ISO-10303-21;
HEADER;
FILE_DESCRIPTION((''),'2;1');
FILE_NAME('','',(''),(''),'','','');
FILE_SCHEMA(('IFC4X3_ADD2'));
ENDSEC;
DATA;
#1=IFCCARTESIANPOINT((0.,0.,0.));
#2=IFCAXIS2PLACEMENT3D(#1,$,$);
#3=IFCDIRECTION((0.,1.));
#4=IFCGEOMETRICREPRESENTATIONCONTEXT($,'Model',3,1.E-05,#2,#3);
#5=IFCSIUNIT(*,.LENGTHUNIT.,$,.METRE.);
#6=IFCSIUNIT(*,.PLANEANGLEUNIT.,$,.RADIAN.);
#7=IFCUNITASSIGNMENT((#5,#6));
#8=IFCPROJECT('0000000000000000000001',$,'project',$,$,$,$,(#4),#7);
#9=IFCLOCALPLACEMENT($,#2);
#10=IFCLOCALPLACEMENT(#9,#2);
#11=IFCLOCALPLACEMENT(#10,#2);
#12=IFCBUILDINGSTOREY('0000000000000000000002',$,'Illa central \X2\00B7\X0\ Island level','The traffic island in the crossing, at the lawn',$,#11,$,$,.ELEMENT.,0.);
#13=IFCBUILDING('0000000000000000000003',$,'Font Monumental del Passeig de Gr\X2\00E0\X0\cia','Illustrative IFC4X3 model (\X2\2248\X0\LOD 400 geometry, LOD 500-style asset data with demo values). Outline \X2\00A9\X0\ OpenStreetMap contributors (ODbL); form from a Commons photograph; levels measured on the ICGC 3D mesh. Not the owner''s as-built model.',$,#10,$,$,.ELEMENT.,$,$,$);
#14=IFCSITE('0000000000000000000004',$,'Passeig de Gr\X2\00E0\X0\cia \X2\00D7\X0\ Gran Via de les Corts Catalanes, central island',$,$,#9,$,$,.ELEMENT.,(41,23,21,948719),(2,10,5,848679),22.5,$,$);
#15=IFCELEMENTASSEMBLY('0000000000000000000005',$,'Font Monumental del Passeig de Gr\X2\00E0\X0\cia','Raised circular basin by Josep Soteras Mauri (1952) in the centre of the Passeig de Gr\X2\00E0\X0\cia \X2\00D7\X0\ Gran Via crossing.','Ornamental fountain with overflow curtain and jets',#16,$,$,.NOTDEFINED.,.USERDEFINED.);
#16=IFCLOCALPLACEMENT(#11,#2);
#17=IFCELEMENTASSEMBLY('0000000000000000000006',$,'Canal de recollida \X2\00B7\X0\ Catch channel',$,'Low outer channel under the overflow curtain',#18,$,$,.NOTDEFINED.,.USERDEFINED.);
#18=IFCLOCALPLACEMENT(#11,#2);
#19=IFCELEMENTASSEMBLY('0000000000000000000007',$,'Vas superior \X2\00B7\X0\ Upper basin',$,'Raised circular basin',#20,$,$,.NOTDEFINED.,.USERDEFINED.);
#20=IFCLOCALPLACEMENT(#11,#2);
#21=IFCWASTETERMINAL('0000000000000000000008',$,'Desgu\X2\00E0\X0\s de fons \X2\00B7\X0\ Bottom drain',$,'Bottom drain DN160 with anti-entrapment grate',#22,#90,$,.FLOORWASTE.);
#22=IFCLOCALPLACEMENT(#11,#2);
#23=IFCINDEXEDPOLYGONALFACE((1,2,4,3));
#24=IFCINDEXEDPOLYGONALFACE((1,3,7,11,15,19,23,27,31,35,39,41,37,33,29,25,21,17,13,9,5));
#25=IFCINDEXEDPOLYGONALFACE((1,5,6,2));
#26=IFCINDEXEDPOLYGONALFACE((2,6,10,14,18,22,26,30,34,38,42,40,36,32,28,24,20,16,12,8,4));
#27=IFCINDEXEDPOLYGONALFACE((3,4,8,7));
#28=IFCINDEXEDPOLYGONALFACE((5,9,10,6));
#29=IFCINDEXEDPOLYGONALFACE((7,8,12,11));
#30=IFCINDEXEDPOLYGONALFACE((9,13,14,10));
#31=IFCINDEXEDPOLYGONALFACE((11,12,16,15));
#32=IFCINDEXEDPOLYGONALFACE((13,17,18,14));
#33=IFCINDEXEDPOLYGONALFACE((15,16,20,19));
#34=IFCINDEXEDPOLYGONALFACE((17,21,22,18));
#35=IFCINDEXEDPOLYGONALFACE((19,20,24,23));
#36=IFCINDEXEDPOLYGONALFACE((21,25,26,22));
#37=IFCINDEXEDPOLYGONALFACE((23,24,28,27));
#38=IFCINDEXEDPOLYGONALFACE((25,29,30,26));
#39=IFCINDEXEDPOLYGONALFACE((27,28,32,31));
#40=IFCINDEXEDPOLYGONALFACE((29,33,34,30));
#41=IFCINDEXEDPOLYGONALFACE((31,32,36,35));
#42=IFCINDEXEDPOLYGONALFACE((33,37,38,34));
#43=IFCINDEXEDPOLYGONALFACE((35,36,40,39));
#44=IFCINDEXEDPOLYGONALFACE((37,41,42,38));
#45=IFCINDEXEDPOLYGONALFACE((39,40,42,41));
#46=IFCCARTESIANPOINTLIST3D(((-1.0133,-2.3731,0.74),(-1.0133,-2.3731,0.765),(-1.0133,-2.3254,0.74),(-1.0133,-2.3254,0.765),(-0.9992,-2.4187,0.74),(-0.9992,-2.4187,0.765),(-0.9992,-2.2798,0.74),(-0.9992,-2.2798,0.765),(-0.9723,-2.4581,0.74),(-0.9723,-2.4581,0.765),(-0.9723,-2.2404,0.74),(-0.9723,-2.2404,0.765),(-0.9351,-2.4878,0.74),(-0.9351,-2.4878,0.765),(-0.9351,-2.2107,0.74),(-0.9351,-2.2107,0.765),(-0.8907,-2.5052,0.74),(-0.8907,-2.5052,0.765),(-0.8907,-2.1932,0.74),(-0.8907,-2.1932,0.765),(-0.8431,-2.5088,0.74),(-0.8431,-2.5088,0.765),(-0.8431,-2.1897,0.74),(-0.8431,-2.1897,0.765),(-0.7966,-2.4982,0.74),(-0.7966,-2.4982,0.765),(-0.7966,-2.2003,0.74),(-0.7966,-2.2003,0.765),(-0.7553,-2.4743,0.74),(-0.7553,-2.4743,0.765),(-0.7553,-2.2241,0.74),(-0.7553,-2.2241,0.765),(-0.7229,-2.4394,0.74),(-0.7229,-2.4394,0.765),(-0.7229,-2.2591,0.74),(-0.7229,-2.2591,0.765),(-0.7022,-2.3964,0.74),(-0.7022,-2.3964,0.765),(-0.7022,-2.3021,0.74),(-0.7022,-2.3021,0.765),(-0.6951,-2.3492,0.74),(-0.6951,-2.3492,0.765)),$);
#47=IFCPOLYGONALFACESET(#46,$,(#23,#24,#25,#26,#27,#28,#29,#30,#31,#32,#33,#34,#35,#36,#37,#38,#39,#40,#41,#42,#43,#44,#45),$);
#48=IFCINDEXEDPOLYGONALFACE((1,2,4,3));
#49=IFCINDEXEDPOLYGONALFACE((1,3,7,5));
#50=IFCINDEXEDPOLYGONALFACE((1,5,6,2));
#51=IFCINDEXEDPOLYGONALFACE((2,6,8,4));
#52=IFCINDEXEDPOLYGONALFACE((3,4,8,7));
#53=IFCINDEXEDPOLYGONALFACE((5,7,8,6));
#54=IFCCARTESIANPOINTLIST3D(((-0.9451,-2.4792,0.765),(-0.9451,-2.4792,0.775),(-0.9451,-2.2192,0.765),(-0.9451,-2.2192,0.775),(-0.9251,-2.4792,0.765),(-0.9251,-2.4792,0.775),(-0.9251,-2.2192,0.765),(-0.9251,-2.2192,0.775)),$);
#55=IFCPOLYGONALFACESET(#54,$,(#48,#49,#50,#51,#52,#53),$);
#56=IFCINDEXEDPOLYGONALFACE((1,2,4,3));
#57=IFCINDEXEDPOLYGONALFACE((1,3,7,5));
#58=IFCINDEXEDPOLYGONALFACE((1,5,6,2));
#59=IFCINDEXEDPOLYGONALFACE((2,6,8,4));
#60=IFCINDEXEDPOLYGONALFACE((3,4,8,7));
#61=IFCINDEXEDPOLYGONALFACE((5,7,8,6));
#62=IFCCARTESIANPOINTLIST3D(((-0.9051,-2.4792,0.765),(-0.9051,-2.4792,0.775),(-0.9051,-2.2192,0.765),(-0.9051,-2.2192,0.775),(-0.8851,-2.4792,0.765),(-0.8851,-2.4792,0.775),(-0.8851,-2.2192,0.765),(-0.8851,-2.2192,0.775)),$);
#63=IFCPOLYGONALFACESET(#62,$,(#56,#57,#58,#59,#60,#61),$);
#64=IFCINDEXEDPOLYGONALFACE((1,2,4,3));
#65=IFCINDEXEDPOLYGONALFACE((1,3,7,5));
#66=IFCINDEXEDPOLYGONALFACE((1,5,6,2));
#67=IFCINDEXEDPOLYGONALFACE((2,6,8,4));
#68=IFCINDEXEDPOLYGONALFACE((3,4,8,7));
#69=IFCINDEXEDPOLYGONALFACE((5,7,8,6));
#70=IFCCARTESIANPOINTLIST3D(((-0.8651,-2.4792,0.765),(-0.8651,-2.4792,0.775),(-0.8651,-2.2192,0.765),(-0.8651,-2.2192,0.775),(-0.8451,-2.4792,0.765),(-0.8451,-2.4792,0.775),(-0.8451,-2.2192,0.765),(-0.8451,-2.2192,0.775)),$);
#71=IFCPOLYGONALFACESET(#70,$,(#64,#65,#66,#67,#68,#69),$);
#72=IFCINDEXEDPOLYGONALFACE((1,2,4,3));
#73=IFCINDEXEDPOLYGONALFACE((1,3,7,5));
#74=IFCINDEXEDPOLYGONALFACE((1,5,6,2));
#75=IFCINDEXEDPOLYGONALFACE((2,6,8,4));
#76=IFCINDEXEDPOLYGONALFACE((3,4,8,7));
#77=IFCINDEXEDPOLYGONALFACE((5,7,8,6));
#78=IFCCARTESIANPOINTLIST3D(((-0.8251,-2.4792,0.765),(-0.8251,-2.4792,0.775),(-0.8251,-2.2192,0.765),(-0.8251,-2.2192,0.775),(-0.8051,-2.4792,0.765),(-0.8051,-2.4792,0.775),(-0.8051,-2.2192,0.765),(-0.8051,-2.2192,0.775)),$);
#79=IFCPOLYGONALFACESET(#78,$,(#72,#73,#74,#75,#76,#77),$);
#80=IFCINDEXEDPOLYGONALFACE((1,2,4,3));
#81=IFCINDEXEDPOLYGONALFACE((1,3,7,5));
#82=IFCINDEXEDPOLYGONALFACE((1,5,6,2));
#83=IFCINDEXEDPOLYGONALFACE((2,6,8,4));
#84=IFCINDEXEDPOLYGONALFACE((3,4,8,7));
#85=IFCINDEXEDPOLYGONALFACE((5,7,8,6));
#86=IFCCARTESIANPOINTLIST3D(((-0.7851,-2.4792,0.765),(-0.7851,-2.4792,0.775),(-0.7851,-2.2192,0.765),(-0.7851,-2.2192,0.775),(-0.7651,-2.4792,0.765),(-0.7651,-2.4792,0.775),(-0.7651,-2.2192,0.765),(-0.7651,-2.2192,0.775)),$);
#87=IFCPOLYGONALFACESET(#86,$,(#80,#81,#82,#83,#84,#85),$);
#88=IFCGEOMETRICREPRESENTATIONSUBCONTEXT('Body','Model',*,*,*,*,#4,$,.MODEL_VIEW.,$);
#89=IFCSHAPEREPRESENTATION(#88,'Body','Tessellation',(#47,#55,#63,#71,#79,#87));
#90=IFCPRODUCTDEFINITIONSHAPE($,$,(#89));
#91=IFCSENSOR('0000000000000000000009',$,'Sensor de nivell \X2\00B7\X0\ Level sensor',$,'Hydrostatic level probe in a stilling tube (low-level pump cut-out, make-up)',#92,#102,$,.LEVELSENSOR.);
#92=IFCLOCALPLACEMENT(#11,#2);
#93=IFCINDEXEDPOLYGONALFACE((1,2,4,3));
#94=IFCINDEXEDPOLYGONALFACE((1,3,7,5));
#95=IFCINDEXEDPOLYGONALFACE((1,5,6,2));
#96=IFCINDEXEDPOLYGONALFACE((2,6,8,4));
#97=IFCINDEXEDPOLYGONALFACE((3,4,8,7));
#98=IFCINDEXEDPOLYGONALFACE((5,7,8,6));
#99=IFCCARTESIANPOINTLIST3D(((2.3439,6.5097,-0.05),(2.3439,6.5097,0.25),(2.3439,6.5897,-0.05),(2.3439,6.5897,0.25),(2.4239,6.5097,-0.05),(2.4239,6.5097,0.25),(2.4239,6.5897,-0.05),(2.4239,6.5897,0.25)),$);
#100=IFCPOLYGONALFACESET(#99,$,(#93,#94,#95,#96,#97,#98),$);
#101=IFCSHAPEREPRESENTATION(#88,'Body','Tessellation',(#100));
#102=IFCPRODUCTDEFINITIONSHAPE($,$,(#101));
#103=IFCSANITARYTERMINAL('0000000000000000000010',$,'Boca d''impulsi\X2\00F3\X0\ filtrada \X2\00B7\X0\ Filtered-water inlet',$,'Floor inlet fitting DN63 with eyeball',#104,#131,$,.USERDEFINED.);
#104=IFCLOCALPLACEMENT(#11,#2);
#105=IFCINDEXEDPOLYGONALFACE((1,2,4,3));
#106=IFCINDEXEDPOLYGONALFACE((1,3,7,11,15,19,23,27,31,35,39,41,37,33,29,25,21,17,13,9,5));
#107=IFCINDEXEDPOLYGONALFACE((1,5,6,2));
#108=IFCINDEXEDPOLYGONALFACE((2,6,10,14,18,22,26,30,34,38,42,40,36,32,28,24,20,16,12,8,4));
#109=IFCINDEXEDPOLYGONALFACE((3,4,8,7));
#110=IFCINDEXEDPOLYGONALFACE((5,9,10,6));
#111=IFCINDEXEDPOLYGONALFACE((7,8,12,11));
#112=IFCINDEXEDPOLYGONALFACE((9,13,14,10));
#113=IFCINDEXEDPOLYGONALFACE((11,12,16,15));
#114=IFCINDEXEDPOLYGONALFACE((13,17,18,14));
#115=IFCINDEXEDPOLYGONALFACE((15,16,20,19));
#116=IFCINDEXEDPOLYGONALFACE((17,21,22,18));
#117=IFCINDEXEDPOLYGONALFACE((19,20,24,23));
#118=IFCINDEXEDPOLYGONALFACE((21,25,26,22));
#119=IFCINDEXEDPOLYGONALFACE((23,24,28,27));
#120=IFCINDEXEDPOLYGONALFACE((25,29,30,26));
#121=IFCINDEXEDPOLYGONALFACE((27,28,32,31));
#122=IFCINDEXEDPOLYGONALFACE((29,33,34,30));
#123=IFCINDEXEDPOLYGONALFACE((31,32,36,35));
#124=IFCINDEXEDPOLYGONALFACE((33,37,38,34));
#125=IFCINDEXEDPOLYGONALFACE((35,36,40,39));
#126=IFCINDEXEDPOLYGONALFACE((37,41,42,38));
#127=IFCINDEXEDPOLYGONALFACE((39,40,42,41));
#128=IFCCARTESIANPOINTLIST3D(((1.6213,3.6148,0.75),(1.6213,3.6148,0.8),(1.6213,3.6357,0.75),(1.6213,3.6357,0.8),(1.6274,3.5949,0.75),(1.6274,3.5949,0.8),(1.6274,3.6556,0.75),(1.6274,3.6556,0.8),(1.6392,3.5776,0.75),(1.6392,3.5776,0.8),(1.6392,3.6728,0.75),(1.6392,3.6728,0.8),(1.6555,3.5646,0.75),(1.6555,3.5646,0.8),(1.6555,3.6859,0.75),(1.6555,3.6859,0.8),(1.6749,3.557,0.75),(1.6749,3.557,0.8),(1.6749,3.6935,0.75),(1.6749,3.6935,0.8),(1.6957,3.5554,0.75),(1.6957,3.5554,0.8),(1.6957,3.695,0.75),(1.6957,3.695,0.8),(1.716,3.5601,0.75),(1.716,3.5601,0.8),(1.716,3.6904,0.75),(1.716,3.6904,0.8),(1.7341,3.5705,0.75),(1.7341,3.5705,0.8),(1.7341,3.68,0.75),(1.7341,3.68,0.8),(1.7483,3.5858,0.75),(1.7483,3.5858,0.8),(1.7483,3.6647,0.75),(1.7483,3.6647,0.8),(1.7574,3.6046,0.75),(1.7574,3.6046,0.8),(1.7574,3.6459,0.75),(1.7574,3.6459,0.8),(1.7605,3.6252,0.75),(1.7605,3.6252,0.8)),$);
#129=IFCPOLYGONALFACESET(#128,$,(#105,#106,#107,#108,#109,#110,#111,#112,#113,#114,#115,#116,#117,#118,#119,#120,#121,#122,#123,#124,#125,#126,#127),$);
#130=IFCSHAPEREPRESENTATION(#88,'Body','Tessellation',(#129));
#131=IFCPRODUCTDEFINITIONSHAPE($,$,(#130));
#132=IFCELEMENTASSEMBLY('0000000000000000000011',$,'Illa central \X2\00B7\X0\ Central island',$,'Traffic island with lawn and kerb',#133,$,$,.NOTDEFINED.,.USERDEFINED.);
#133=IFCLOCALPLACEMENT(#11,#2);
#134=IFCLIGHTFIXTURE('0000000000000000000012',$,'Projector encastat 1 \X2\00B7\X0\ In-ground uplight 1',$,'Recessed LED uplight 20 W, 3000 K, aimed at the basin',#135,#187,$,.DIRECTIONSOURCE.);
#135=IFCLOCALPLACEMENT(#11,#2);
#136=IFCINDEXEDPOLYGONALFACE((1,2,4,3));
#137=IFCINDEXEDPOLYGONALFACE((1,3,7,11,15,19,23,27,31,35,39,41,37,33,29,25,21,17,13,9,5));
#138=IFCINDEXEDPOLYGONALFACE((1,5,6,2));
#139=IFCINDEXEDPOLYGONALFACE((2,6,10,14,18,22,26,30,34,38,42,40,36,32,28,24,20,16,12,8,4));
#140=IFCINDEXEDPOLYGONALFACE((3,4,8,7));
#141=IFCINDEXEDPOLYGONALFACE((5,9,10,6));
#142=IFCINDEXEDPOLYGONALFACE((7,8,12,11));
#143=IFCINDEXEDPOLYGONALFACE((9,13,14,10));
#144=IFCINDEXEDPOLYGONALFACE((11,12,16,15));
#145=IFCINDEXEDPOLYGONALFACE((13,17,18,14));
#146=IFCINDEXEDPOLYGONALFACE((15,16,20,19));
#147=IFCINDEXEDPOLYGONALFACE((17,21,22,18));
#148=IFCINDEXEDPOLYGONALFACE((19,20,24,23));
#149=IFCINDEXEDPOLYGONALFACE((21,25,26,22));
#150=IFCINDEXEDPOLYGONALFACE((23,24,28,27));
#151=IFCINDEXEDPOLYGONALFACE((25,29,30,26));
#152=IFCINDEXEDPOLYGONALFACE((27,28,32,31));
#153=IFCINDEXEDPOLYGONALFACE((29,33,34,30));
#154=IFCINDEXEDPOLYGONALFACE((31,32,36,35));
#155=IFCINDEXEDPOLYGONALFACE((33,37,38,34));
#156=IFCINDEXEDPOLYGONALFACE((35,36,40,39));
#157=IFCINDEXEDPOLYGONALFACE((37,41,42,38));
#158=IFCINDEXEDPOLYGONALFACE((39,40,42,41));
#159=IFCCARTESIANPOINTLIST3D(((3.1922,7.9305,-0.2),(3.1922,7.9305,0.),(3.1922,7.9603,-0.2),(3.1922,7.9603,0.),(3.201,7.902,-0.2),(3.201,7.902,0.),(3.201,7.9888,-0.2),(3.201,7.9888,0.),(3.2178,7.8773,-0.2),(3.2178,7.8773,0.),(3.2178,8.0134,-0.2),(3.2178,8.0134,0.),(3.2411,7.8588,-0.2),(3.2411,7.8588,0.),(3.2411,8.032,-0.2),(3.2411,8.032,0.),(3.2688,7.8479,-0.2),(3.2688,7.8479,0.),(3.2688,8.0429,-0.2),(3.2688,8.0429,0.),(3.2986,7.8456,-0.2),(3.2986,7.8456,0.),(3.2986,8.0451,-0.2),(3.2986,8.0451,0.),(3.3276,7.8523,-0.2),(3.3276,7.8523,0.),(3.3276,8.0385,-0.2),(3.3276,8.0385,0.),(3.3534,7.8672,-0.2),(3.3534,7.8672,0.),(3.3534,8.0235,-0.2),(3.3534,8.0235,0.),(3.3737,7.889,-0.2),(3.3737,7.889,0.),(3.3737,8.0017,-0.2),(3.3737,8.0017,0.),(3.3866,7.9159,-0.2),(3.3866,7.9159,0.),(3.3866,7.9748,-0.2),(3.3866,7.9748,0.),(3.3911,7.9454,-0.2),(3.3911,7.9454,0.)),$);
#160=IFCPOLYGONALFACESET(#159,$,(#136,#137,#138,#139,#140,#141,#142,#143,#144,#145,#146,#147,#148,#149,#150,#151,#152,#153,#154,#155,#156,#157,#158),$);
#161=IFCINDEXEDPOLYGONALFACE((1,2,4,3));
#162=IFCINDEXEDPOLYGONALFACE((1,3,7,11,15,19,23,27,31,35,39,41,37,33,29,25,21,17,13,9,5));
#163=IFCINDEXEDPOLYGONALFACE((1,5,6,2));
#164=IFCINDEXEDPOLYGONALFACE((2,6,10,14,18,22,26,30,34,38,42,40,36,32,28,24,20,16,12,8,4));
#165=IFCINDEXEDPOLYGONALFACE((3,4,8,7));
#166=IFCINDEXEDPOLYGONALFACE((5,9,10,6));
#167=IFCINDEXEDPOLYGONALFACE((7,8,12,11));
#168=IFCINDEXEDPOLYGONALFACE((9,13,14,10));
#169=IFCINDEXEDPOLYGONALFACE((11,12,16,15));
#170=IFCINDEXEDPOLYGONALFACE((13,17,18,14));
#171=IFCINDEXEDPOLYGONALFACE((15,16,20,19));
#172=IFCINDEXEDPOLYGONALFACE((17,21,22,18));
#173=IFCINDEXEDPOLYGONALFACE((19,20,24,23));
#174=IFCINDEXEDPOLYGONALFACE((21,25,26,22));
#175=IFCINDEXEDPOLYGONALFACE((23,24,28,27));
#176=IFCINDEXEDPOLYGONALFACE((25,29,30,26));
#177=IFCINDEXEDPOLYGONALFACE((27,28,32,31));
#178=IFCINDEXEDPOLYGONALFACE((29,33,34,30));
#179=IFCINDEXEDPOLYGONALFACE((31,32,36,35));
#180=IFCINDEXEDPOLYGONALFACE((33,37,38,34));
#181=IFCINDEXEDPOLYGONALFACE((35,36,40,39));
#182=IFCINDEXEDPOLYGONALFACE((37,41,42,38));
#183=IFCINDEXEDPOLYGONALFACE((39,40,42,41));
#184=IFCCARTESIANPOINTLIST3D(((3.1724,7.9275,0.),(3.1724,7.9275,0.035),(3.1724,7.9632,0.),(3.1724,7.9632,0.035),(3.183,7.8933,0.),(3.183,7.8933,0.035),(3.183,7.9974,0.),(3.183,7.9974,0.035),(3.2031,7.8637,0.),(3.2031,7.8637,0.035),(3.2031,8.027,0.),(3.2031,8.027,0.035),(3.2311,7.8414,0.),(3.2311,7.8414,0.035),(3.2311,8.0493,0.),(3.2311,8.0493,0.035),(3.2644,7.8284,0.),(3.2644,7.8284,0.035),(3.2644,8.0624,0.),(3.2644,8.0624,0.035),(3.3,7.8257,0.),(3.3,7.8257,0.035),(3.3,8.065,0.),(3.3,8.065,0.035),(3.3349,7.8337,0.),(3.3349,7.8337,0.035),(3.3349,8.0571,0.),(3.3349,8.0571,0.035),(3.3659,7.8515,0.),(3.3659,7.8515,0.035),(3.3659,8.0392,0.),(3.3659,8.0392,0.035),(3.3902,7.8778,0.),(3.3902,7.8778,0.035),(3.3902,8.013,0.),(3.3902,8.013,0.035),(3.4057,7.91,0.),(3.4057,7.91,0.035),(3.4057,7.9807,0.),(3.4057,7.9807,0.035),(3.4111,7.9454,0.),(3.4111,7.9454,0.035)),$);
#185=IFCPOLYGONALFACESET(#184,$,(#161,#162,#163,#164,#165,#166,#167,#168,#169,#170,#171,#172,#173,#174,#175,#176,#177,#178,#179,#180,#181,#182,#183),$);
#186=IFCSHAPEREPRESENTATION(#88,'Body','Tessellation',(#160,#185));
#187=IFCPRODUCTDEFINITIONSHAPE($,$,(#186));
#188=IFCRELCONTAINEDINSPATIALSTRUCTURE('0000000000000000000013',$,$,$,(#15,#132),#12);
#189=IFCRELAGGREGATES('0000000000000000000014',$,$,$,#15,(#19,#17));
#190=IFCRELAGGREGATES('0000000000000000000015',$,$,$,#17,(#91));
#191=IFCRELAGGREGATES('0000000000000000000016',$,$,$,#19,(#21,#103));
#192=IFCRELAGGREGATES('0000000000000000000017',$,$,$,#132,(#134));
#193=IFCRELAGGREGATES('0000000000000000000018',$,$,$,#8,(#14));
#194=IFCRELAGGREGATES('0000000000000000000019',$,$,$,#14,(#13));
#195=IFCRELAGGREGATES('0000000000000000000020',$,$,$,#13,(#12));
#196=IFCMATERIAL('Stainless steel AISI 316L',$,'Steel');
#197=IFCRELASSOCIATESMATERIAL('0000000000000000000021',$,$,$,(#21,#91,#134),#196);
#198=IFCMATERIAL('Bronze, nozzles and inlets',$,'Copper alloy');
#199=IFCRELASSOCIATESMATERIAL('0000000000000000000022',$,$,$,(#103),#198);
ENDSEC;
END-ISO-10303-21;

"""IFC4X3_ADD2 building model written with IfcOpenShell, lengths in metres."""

from ifc_helpers import new_model, si_unit, direction, frame, origin, origin_2d_with_axis, place, context, subcontext, project, spatial, rectangle, circle, extrude, material, element, aggregate, save


model = new_model("IFC4X3_ADD2")

# Units and contexts
model_context = context("Model", 3, precision=1e-05, world=origin(), true_north=direction((0.0, 1.0)))
body_context = subcontext(model_context, "Body", "Model", "MODEL_VIEW")
ifc_project = project(units=[si_unit("LENGTHUNIT", "METRE"), si_unit("PLANEANGLEUNIT", "RADIAN")], contexts=[model_context])

# Site, building, storey
site_placement = place(None, origin())
site = spatial("IfcSite", under=ifc_project, at=site_placement, Name="Passeig de Gràcia × Gran Via de les Corts Catalanes, central island", CompositionType="ELEMENT", RefLatitude=(41, 23, 21, 948719), RefLongitude=(2, 10, 5, 848679), RefElevation=22.5)
building_placement = place(site_placement, origin())
building = spatial("IfcBuilding", under=site, at=building_placement, Name="Font Monumental del Passeig de Gràcia", Description="Illustrative IFC4X3 model (≈LOD 400 geometry, LOD 500-style asset data with demo values). Outline © OpenStreetMap contributors (ODbL); form from a Commons photograph; levels measured on the ICGC 3D mesh. Not the owner's as-built model.", CompositionType="ELEMENT")
storey_placement = place(building_placement, origin())
storey = spatial("IfcBuildingStorey", under=building, at=storey_placement, Name="Illa central · Island level", Description="The traffic island in the crossing, at the lawn", CompositionType="ELEMENT", Elevation=0.0)

# Element assemblies, waste terminal, sensor, sanitary terminal
assembly_1_placement = place(building_placement, origin())
assembly_1 = element("IfcElementAssembly", 1, at=assembly_1_placement, inside=storey, Name="Font Monumental del Passeig de Gràcia", Description="Raised circular basin by Josep Soteras Mauri (1952) in the centre of the Passeig de Gràcia × Gran Via crossing.", ObjectType="Ornamental fountain with overflow curtain and jets", AssemblyPlace="NOTDEFINED", PredefinedType="USERDEFINED")
ifc_material_1 = material(Name="Stainless steel AISI 316L", Category="Steel")
ifc_material_2 = material(Name="Bronze, nozzles and inlets", Category="Copper alloy")
assembly_2_placement = place(building_placement, origin())
assembly_2 = element("IfcElementAssembly", 2, at=assembly_2_placement, Name="Canal de recollida · Catch channel", ObjectType="Low outer channel under the overflow curtain", AssemblyPlace="NOTDEFINED", PredefinedType="USERDEFINED")
assembly_3_placement = place(building_placement, origin())
assembly_3 = element("IfcElementAssembly", 3, at=assembly_3_placement, Name="Vas superior · Upper basin", ObjectType="Raised circular basin", AssemblyPlace="NOTDEFINED", PredefinedType="USERDEFINED")
aggregate(assembly_1, [assembly_3, assembly_2])
waste_terminal_1_placement = place(building_placement, origin())
waste_terminal_1 = element("IfcWasteTerminal", 4, at=waste_terminal_1_placement, material=ifc_material_1, Name="Desguàs de fons · Bottom drain", ObjectType="Bottom drain DN160 with anti-entrapment grate", PredefinedType="FLOORWASTE", context=body_context, shape_type="SweptSolid", body=[
    extrude(circle(Radius=0.16, at=origin_2d_with_axis()), frame((-0.8551, -2.3492, 0.74)), (0.0, 0.0, 1.0), 0.025),
    extrude(rectangle(XDim=0.02, YDim=0.26, at=origin_2d_with_axis()), frame((-0.9351, -2.3492, 0.765)), (0.0, 0.0, 1.0), 0.01),
    extrude(rectangle(XDim=0.02, YDim=0.26, at=origin_2d_with_axis()), frame((-0.8951, -2.3492, 0.765)), (0.0, 0.0, 1.0), 0.01),
    extrude(rectangle(XDim=0.02, YDim=0.26, at=origin_2d_with_axis()), frame((-0.8551, -2.3492, 0.765)), (0.0, 0.0, 1.0), 0.01),
    extrude(rectangle(XDim=0.02, YDim=0.26, at=origin_2d_with_axis()), frame((-0.8151, -2.3492, 0.765)), (0.0, 0.0, 1.0), 0.01),
    extrude(rectangle(XDim=0.02, YDim=0.26, at=origin_2d_with_axis()), frame((-0.7751, -2.3492, 0.765)), (0.0, 0.0, 1.0), 0.01),
])
sensor_placement = place(building_placement, origin())
sensor = element("IfcSensor", 5, at=sensor_placement, material=ifc_material_1, Name="Sensor de nivell · Level sensor", ObjectType="Hydrostatic level probe in a stilling tube (low-level pump cut-out, make-up)", PredefinedType="LEVELSENSOR", context=body_context, shape_type="SweptSolid", body=[
    extrude(rectangle(XDim=0.08, YDim=0.08, at=origin_2d_with_axis()), frame((2.3839, 6.5497, -0.05)), (0.0, 0.0, 1.0), 0.3),
])
aggregate(assembly_2, [sensor])
sanitary_terminal_1_placement = place(building_placement, origin())
sanitary_terminal_1 = element("IfcSanitaryTerminal", 6, at=sanitary_terminal_1_placement, material=ifc_material_2, Name="Boca d'impulsió filtrada · Filtered-water inlet", ObjectType="Floor inlet fitting DN63 with eyeball", PredefinedType="USERDEFINED", context=body_context, shape_type="SweptSolid", body=[
    extrude(circle(Radius=0.07, at=origin_2d_with_axis()), frame((1.6905, 3.6252, 0.75)), (0.0, 0.0, 1.0), 0.05),
])
aggregate(assembly_3, [waste_terminal_1, sanitary_terminal_1])

# Element assembly, light fixture
assembly_4_placement = place(building_placement, origin())
assembly_4 = element("IfcElementAssembly", 7, at=assembly_4_placement, inside=storey, Name="Illa central · Central island", ObjectType="Traffic island with lawn and kerb", AssemblyPlace="NOTDEFINED", PredefinedType="USERDEFINED")
light_fixture_1_placement = place(building_placement, origin())
light_fixture_1 = element("IfcLightFixture", 8, at=light_fixture_1_placement, material=ifc_material_1, Name="Projector encastat 1 · In-ground uplight 1", ObjectType="Recessed LED uplight 20 W, 3000 K, aimed at the basin", PredefinedType="DIRECTIONSOURCE", context=body_context, shape_type="SweptSolid", body=[
    extrude(circle(Radius=0.1, at=origin_2d_with_axis()), frame((3.2911, 7.9454, -0.2)), (0.0, 0.0, 1.0), 0.2),
    extrude(circle(Radius=0.12, at=origin_2d_with_axis()), frame((3.2911, 7.9454, 0.0)), (0.0, 0.0, 1.0), 0.035),
])

aggregate(assembly_4, [light_fixture_1])

save(model, "model.ifc")
